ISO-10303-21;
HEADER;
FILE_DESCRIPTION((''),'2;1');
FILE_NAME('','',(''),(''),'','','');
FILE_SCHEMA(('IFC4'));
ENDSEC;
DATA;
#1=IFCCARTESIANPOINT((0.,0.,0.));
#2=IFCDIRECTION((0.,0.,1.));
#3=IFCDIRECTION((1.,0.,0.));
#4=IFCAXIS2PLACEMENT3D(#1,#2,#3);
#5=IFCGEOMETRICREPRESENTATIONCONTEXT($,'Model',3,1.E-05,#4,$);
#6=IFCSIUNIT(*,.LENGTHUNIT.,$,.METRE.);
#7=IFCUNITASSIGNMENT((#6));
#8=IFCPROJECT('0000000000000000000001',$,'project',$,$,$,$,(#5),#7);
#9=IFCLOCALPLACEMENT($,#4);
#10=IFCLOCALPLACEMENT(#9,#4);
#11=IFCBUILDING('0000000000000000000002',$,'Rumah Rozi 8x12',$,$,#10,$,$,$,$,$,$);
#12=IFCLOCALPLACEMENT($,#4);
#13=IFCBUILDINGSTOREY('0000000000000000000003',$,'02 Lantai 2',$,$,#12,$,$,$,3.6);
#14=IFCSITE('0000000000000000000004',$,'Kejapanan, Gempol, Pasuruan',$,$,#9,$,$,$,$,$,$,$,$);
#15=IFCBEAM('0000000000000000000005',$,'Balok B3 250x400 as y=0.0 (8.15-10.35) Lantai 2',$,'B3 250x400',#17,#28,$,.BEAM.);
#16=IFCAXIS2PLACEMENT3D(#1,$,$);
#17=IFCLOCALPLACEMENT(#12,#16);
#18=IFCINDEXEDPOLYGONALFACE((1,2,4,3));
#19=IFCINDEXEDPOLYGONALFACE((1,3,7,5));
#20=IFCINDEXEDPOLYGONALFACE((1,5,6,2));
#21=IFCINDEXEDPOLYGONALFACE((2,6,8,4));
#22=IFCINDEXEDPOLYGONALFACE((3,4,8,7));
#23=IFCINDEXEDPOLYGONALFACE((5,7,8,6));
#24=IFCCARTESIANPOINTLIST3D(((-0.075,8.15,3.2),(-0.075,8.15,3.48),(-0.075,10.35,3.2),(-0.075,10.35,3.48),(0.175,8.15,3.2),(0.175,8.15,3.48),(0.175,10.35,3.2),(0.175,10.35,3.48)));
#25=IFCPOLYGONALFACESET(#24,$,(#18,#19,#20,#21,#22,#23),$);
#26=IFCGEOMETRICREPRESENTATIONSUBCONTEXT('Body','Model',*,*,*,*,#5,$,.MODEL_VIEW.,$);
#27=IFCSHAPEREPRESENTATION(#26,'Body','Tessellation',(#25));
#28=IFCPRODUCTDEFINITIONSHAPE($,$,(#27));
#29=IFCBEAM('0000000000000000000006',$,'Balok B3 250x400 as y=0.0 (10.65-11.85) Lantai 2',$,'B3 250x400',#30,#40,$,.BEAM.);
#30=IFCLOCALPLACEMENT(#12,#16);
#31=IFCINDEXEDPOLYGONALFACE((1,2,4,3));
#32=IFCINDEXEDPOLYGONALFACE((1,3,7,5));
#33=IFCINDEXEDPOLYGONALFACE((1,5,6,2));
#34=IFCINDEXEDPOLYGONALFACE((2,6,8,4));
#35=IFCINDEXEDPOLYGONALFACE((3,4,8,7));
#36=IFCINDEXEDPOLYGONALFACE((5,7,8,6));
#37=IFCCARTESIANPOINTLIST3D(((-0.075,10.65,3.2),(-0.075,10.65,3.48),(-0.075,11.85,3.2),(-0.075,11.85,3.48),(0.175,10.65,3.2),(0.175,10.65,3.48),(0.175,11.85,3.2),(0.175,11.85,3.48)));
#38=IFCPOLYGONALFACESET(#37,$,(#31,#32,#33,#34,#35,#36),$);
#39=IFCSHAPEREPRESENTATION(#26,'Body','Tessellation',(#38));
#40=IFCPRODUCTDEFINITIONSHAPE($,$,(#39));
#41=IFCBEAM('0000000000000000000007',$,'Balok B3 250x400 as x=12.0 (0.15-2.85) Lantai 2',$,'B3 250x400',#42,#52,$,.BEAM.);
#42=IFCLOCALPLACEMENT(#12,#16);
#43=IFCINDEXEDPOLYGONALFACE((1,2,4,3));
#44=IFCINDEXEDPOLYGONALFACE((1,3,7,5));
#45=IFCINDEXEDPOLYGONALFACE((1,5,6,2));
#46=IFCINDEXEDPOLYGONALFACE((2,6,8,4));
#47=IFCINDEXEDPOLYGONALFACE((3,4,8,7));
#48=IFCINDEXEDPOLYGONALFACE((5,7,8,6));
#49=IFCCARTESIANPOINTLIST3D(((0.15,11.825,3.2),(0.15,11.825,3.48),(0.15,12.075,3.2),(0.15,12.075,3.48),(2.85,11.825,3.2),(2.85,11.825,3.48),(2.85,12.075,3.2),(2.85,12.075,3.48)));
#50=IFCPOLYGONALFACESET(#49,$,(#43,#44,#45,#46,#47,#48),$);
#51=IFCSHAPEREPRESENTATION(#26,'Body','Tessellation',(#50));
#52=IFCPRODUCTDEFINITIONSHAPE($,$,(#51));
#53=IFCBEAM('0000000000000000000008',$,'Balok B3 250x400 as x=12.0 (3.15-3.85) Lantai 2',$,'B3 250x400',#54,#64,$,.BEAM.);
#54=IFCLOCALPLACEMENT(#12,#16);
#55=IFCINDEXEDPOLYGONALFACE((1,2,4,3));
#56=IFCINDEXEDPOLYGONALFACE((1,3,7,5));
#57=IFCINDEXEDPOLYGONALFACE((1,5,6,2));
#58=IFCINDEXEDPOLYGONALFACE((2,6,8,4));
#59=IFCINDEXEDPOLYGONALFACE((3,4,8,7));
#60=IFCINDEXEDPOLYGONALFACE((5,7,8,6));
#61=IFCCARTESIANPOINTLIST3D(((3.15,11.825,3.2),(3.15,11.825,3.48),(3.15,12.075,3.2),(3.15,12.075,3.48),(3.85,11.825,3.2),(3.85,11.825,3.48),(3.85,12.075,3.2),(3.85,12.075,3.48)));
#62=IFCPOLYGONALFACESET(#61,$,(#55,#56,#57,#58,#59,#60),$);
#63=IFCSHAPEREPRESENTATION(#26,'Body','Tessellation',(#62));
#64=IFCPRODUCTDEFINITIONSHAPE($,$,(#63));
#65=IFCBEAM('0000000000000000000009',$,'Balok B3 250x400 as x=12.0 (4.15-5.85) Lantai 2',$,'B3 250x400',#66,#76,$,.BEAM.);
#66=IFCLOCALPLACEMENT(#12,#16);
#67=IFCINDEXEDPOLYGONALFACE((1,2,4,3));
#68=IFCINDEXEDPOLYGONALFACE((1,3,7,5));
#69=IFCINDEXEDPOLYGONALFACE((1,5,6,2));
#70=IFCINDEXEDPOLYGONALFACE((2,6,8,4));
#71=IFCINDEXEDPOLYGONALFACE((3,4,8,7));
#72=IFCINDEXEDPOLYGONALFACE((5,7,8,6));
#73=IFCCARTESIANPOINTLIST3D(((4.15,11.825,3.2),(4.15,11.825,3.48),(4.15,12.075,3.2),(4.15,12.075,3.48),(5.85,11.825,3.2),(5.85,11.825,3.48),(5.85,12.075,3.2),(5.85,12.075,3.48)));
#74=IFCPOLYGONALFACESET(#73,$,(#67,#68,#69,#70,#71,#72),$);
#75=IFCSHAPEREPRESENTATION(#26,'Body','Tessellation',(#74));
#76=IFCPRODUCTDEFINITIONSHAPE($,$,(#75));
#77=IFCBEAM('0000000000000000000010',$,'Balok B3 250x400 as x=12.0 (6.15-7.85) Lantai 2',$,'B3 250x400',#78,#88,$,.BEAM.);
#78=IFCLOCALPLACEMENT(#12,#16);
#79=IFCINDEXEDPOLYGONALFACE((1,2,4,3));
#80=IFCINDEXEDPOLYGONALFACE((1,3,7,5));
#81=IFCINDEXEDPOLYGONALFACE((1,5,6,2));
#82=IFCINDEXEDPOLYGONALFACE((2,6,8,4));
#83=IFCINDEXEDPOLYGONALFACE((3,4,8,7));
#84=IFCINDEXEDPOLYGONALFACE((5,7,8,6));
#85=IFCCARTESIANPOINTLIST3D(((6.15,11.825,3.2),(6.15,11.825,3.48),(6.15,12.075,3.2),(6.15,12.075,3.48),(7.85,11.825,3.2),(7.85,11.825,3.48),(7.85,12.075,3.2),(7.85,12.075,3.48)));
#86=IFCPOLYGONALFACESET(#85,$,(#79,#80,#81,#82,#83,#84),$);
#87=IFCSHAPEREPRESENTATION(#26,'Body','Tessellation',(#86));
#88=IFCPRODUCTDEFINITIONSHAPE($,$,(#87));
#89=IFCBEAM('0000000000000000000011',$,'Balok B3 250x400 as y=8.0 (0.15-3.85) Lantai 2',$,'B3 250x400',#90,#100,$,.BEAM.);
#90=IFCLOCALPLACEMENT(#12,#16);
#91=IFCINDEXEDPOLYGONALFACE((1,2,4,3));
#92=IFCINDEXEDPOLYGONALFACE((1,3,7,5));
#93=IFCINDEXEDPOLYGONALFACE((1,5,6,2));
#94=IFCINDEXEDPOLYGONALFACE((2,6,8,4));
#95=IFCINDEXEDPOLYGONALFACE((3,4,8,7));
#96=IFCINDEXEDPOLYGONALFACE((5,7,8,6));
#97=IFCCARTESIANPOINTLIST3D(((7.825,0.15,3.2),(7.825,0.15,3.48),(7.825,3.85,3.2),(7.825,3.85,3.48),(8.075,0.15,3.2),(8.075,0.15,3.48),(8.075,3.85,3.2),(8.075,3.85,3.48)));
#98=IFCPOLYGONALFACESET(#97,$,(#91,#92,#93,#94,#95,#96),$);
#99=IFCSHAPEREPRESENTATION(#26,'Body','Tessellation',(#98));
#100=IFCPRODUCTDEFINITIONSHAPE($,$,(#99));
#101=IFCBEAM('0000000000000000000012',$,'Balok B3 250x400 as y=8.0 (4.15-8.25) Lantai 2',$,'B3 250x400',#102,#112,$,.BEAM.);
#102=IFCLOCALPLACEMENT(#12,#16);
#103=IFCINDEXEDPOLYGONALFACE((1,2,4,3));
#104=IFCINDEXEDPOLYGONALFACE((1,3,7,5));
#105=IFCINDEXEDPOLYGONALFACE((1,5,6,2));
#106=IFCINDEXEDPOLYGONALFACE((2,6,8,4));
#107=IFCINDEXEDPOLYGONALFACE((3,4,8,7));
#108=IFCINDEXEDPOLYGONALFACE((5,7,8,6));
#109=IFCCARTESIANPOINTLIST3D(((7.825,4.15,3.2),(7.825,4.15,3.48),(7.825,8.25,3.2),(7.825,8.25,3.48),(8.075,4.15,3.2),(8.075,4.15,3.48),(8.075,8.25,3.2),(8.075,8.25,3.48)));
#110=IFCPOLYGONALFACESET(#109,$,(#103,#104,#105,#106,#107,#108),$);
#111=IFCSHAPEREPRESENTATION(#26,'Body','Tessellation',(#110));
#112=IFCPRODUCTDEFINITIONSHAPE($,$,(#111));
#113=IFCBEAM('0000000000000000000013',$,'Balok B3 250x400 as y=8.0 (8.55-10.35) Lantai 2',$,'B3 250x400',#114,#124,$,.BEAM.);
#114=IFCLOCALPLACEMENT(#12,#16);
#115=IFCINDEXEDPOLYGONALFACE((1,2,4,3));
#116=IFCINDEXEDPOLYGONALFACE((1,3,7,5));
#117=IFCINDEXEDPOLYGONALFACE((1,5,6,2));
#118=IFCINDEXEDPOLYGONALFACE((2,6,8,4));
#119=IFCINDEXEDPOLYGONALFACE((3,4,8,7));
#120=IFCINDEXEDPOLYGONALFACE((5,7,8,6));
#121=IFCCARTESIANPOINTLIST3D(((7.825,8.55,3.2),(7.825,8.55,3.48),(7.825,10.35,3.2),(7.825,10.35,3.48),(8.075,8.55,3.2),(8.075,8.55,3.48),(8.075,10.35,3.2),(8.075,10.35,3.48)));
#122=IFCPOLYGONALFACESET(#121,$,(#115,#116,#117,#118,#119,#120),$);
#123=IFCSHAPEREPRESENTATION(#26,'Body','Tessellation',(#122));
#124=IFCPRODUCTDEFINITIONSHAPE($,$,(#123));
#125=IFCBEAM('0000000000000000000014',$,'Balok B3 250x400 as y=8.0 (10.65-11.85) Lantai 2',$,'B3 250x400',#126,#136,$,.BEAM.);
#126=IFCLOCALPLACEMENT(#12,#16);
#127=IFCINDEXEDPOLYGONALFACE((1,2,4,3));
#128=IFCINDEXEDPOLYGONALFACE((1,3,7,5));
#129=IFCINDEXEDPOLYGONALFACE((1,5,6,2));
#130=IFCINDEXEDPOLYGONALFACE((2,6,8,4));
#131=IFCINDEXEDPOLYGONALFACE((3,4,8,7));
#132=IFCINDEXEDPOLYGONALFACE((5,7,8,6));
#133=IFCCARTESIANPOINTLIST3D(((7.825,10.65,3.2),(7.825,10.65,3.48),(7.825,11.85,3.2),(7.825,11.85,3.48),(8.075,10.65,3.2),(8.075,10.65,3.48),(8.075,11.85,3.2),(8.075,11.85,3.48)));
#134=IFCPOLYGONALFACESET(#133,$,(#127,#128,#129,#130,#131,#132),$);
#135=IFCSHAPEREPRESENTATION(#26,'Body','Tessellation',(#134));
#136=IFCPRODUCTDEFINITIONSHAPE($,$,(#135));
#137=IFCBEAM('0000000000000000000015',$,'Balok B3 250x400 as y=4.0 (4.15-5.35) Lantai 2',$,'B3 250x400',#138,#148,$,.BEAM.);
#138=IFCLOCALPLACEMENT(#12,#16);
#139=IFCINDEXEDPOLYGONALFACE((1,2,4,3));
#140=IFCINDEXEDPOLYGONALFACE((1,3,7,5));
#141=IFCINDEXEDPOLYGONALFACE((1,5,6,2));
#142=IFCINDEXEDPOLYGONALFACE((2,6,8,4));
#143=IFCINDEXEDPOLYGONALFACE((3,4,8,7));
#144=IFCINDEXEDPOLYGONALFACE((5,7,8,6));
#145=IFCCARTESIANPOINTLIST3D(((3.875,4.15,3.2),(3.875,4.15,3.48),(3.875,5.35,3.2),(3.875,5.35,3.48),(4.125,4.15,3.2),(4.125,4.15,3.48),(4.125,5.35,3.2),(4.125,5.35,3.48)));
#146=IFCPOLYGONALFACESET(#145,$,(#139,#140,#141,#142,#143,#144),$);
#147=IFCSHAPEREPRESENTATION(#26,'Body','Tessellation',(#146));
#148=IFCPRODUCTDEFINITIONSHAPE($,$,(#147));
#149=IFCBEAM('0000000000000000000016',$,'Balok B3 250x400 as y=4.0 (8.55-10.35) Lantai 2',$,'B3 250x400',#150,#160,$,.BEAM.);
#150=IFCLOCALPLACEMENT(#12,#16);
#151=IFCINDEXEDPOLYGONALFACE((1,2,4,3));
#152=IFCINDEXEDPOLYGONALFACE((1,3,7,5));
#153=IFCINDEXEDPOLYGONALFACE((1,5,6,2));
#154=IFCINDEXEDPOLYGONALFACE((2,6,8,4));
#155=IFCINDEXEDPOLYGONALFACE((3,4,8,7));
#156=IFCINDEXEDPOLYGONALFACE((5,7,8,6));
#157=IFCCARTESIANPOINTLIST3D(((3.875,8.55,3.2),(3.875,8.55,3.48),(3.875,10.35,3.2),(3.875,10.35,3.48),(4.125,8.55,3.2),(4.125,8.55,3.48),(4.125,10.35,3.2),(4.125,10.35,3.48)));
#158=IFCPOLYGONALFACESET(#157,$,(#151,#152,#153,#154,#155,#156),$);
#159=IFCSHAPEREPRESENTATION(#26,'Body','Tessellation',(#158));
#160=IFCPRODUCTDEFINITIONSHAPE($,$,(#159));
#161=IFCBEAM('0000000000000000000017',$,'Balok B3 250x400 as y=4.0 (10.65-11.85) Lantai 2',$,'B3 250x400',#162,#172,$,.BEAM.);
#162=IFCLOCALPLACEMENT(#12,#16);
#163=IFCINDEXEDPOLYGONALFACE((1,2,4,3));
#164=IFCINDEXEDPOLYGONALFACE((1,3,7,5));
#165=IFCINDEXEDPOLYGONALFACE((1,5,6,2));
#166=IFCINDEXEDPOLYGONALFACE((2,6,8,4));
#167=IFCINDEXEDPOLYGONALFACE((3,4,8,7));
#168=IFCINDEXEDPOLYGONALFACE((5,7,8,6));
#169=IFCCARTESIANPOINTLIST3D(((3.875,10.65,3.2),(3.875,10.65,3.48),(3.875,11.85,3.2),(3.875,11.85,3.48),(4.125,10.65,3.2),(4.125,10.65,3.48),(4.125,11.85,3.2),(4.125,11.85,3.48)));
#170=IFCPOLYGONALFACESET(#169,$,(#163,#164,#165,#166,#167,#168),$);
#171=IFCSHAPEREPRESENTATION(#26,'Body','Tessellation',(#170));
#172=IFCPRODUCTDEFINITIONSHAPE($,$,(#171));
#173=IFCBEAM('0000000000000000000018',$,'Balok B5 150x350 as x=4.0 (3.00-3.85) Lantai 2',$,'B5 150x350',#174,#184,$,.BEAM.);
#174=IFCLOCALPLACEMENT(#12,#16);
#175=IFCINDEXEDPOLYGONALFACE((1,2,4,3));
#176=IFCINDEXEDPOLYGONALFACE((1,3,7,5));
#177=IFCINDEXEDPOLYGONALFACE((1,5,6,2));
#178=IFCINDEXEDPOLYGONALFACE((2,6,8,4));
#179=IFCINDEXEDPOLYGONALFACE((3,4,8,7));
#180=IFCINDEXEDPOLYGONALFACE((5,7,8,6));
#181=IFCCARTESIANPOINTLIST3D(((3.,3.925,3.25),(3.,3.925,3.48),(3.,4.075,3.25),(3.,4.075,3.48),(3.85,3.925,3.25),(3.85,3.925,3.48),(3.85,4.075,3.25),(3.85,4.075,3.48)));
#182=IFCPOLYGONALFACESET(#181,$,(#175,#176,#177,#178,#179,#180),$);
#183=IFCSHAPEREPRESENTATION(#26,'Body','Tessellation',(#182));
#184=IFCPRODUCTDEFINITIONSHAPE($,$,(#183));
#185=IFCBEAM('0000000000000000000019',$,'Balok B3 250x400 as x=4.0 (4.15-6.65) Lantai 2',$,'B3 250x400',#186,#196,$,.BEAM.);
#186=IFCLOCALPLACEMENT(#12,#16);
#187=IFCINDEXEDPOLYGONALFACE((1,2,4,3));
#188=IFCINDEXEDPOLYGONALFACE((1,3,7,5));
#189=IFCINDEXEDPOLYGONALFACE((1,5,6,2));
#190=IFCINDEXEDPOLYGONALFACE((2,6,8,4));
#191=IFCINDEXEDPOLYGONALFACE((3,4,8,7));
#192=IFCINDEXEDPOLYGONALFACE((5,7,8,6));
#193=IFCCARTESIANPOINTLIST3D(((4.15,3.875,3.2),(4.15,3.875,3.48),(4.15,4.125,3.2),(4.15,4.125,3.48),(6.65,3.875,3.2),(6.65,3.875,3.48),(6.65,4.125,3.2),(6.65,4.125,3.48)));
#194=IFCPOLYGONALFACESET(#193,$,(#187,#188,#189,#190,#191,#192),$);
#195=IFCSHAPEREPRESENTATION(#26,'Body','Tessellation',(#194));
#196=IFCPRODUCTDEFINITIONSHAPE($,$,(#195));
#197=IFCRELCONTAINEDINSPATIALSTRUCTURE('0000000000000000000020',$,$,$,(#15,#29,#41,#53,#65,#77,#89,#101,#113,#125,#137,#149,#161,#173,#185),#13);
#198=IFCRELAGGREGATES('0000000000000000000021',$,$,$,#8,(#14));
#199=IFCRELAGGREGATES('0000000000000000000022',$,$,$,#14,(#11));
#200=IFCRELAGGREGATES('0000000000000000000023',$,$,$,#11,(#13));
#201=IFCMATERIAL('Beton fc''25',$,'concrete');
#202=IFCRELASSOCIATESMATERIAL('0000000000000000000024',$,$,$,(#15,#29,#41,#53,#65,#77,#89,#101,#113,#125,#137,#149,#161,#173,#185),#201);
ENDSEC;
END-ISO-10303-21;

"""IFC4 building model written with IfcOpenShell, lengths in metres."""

from ifc_helpers import new_model, si_unit, frame, origin_with_axes, place, context, subcontext, project, spatial, line, indexed_curve, outline, extrude, material, element, save


model = new_model("IFC4")

# Units and contexts
model_context = context("Model", 3, precision=1e-05, world=origin_with_axes())
body_context = subcontext(model_context, "Body", "Model", "MODEL_VIEW")
ifc_project = project(units=[si_unit("LENGTHUNIT", "METRE")], contexts=[model_context])

# Site, building, storey
site_placement = place(None, origin_with_axes())
site = spatial("IfcSite", under=ifc_project, at=site_placement, Name="Kejapanan, Gempol, Pasuruan")
building_placement = place(site_placement, origin_with_axes())
building = spatial("IfcBuilding", under=site, at=building_placement, Name="Rumah Rozi 8x12")
storey_placement = place(None, origin_with_axes())
storey = spatial("IfcBuildingStorey", under=building, at=storey_placement, Name="02 Lantai 2", Elevation=3.6)

# Beams
ifc_material = material(Name="Beton fc'25", Category="concrete")
beam_1_placement = place(storey_placement, origin_with_axes())
element("IfcBeam", 1, at=beam_1_placement, inside=storey, material=ifc_material, Name="Balok B3 250x400 as y=0.0 (8.15-10.35) Lantai 2", ObjectType="B3 250x400", PredefinedType="BEAM", context=body_context, shape_type="SweptSolid", body=[
    extrude(outline(indexed_curve([(-0.075, 8.15), (0.175, 8.15), (0.175, 10.35), (-0.075, 10.35)], segments=[line(1, 2, 3, 4, 1)])), frame((0.0, 0.0, 3.2), z_axis=(0.0, 0.0, 1.0), x_axis=(1.0, 0.0, 0.0)), (0.0, 0.0, 1.0), 0.28),
])
beam_2_placement = place(storey_placement, origin_with_axes())
element("IfcBeam", 2, at=beam_2_placement, inside=storey, material=ifc_material, Name="Balok B3 250x400 as y=0.0 (10.65-11.85) Lantai 2", ObjectType="B3 250x400", PredefinedType="BEAM", context=body_context, shape_type="SweptSolid", body=[
    extrude(outline(indexed_curve([(-0.075, 10.65), (0.175, 10.65), (0.175, 11.85), (-0.075, 11.85)], segments=[line(1, 2, 3, 4, 1)])), frame((0.0, 0.0, 3.2), z_axis=(0.0, 0.0, 1.0), x_axis=(1.0, 0.0, 0.0)), (0.0, 0.0, 1.0), 0.28),
])
beam_3_placement = place(storey_placement, origin_with_axes())
element("IfcBeam", 3, at=beam_3_placement, inside=storey, material=ifc_material, Name="Balok B3 250x400 as x=12.0 (0.15-2.85) Lantai 2", ObjectType="B3 250x400", PredefinedType="BEAM", context=body_context, shape_type="SweptSolid", body=[
    extrude(outline(indexed_curve([(0.15, 11.825), (2.85, 11.825), (2.85, 12.075), (0.15, 12.075)], segments=[line(1, 2, 3, 4, 1)])), frame((0.0, 0.0, 3.2), z_axis=(0.0, 0.0, 1.0), x_axis=(1.0, 0.0, 0.0)), (0.0, 0.0, 1.0), 0.28),
])
beam_4_placement = place(storey_placement, origin_with_axes())
element("IfcBeam", 4, at=beam_4_placement, inside=storey, material=ifc_material, Name="Balok B3 250x400 as x=12.0 (3.15-3.85) Lantai 2", ObjectType="B3 250x400", PredefinedType="BEAM", context=body_context, shape_type="SweptSolid", body=[
    extrude(outline(indexed_curve([(3.15, 11.825), (3.85, 11.825), (3.85, 12.075), (3.15, 12.075)], segments=[line(1, 2, 3, 4, 1)])), frame((0.0, 0.0, 3.2), z_axis=(0.0, 0.0, 1.0), x_axis=(1.0, 0.0, 0.0)), (0.0, 0.0, 1.0), 0.28),
])
beam_5_placement = place(storey_placement, origin_with_axes())
element("IfcBeam", 5, at=beam_5_placement, inside=storey, material=ifc_material, Name="Balok B3 250x400 as x=12.0 (4.15-5.85) Lantai 2", ObjectType="B3 250x400", PredefinedType="BEAM", context=body_context, shape_type="SweptSolid", body=[
    extrude(outline(indexed_curve([(4.15, 11.825), (5.85, 11.825), (5.85, 12.075), (4.15, 12.075)], segments=[line(1, 2, 3, 4, 1)])), frame((0.0, 0.0, 3.2), z_axis=(0.0, 0.0, 1.0), x_axis=(1.0, 0.0, 0.0)), (0.0, 0.0, 1.0), 0.28),
])
beam_6_placement = place(storey_placement, origin_with_axes())
element("IfcBeam", 6, at=beam_6_placement, inside=storey, material=ifc_material, Name="Balok B3 250x400 as x=12.0 (6.15-7.85) Lantai 2", ObjectType="B3 250x400", PredefinedType="BEAM", context=body_context, shape_type="SweptSolid", body=[
    extrude(outline(indexed_curve([(6.15, 11.825), (7.85, 11.825), (7.85, 12.075), (6.15, 12.075)], segments=[line(1, 2, 3, 4, 1)])), frame((0.0, 0.0, 3.2), z_axis=(0.0, 0.0, 1.0), x_axis=(1.0, 0.0, 0.0)), (0.0, 0.0, 1.0), 0.28),
])
beam_7_placement = place(storey_placement, origin_with_axes())
element("IfcBeam", 7, at=beam_7_placement, inside=storey, material=ifc_material, Name="Balok B3 250x400 as y=8.0 (0.15-3.85) Lantai 2", ObjectType="B3 250x400", PredefinedType="BEAM", context=body_context, shape_type="SweptSolid", body=[
    extrude(outline(indexed_curve([(7.825, 0.15), (8.075, 0.15), (8.075, 3.85), (7.825, 3.85)], segments=[line(1, 2, 3, 4, 1)])), frame((0.0, 0.0, 3.2), z_axis=(0.0, 0.0, 1.0), x_axis=(1.0, 0.0, 0.0)), (0.0, 0.0, 1.0), 0.28),
])
beam_8_placement = place(storey_placement, origin_with_axes())
element("IfcBeam", 8, at=beam_8_placement, inside=storey, material=ifc_material, Name="Balok B3 250x400 as y=8.0 (4.15-8.25) Lantai 2", ObjectType="B3 250x400", PredefinedType="BEAM", context=body_context, shape_type="SweptSolid", body=[
    extrude(outline(indexed_curve([(7.825, 4.15), (8.075, 4.15), (8.075, 8.25), (7.825, 8.25)], segments=[line(1, 2, 3, 4, 1)])), frame((0.0, 0.0, 3.2), z_axis=(0.0, 0.0, 1.0), x_axis=(1.0, 0.0, 0.0)), (0.0, 0.0, 1.0), 0.28),
])
beam_9_placement = place(storey_placement, origin_with_axes())
element("IfcBeam", 9, at=beam_9_placement, inside=storey, material=ifc_material, Name="Balok B3 250x400 as y=8.0 (8.55-10.35) Lantai 2", ObjectType="B3 250x400", PredefinedType="BEAM", context=body_context, shape_type="SweptSolid", body=[
    extrude(outline(indexed_curve([(7.825, 8.55), (8.075, 8.55), (8.075, 10.35), (7.825, 10.35)], segments=[line(1, 2, 3, 4, 1)])), frame((0.0, 0.0, 3.2), z_axis=(0.0, 0.0, 1.0), x_axis=(1.0, 0.0, 0.0)), (0.0, 0.0, 1.0), 0.28),
])
beam_10_placement = place(storey_placement, origin_with_axes())
element("IfcBeam", 10, at=beam_10_placement, inside=storey, material=ifc_material, Name="Balok B3 250x400 as y=8.0 (10.65-11.85) Lantai 2", ObjectType="B3 250x400", PredefinedType="BEAM", context=body_context, shape_type="SweptSolid", body=[
    extrude(outline(indexed_curve([(7.825, 10.65), (8.075, 10.65), (8.075, 11.85), (7.825, 11.85)], segments=[line(1, 2, 3, 4, 1)])), frame((0.0, 0.0, 3.2), z_axis=(0.0, 0.0, 1.0), x_axis=(1.0, 0.0, 0.0)), (0.0, 0.0, 1.0), 0.28),
])
beam_11_placement = place(storey_placement, origin_with_axes())
element("IfcBeam", 11, at=beam_11_placement, inside=storey, material=ifc_material, Name="Balok B3 250x400 as y=4.0 (4.15-5.35) Lantai 2", ObjectType="B3 250x400", PredefinedType="BEAM", context=body_context, shape_type="SweptSolid", body=[
    extrude(outline(indexed_curve([(3.875, 4.15), (4.125, 4.15), (4.125, 5.35), (3.875, 5.35)], segments=[line(1, 2, 3, 4, 1)])), frame((0.0, 0.0, 3.2), z_axis=(0.0, 0.0, 1.0), x_axis=(1.0, 0.0, 0.0)), (0.0, 0.0, 1.0), 0.28),
])
beam_12_placement = place(storey_placement, origin_with_axes())
element("IfcBeam", 12, at=beam_12_placement, inside=storey, material=ifc_material, Name="Balok B3 250x400 as y=4.0 (8.55-10.35) Lantai 2", ObjectType="B3 250x400", PredefinedType="BEAM", context=body_context, shape_type="SweptSolid", body=[
    extrude(outline(indexed_curve([(3.875, 8.55), (4.125, 8.55), (4.125, 10.35), (3.875, 10.35)], segments=[line(1, 2, 3, 4, 1)])), frame((0.0, 0.0, 3.2), z_axis=(0.0, 0.0, 1.0), x_axis=(1.0, 0.0, 0.0)), (0.0, 0.0, 1.0), 0.28),
])
beam_13_placement = place(storey_placement, origin_with_axes())
element("IfcBeam", 13, at=beam_13_placement, inside=storey, material=ifc_material, Name="Balok B3 250x400 as y=4.0 (10.65-11.85) Lantai 2", ObjectType="B3 250x400", PredefinedType="BEAM", context=body_context, shape_type="SweptSolid", body=[
    extrude(outline(indexed_curve([(3.875, 10.65), (4.125, 10.65), (4.125, 11.85), (3.875, 11.85)], segments=[line(1, 2, 3, 4, 1)])), frame((0.0, 0.0, 3.2), z_axis=(0.0, 0.0, 1.0), x_axis=(1.0, 0.0, 0.0)), (0.0, 0.0, 1.0), 0.28),
])
beam_14_placement = place(storey_placement, origin_with_axes())
element("IfcBeam", 14, at=beam_14_placement, inside=storey, material=ifc_material, Name="Balok B5 150x350 as x=4.0 (3.00-3.85) Lantai 2", ObjectType="B5 150x350", PredefinedType="BEAM", context=body_context, shape_type="SweptSolid", body=[
    extrude(outline(indexed_curve([(3.0, 3.925), (3.85, 3.925), (3.85, 4.075), (3.0, 4.075)], segments=[line(1, 2, 3, 4, 1)])), frame((0.0, 0.0, 3.25), z_axis=(0.0, 0.0, 1.0), x_axis=(1.0, 0.0, 0.0)), (0.0, 0.0, 1.0), 0.23),
])
beam_15_placement = place(storey_placement, origin_with_axes())
element("IfcBeam", 15, at=beam_15_placement, inside=storey, material=ifc_material, Name="Balok B3 250x400 as x=4.0 (4.15-6.65) Lantai 2", ObjectType="B3 250x400", PredefinedType="BEAM", context=body_context, shape_type="SweptSolid", body=[
    extrude(outline(indexed_curve([(4.15, 3.875), (6.65, 3.875), (6.65, 4.125), (4.15, 4.125)], segments=[line(1, 2, 3, 4, 1)])), frame((0.0, 0.0, 3.2), z_axis=(0.0, 0.0, 1.0), x_axis=(1.0, 0.0, 0.0)), (0.0, 0.0, 1.0), 0.28),
])

save(model, "model.ifc")
